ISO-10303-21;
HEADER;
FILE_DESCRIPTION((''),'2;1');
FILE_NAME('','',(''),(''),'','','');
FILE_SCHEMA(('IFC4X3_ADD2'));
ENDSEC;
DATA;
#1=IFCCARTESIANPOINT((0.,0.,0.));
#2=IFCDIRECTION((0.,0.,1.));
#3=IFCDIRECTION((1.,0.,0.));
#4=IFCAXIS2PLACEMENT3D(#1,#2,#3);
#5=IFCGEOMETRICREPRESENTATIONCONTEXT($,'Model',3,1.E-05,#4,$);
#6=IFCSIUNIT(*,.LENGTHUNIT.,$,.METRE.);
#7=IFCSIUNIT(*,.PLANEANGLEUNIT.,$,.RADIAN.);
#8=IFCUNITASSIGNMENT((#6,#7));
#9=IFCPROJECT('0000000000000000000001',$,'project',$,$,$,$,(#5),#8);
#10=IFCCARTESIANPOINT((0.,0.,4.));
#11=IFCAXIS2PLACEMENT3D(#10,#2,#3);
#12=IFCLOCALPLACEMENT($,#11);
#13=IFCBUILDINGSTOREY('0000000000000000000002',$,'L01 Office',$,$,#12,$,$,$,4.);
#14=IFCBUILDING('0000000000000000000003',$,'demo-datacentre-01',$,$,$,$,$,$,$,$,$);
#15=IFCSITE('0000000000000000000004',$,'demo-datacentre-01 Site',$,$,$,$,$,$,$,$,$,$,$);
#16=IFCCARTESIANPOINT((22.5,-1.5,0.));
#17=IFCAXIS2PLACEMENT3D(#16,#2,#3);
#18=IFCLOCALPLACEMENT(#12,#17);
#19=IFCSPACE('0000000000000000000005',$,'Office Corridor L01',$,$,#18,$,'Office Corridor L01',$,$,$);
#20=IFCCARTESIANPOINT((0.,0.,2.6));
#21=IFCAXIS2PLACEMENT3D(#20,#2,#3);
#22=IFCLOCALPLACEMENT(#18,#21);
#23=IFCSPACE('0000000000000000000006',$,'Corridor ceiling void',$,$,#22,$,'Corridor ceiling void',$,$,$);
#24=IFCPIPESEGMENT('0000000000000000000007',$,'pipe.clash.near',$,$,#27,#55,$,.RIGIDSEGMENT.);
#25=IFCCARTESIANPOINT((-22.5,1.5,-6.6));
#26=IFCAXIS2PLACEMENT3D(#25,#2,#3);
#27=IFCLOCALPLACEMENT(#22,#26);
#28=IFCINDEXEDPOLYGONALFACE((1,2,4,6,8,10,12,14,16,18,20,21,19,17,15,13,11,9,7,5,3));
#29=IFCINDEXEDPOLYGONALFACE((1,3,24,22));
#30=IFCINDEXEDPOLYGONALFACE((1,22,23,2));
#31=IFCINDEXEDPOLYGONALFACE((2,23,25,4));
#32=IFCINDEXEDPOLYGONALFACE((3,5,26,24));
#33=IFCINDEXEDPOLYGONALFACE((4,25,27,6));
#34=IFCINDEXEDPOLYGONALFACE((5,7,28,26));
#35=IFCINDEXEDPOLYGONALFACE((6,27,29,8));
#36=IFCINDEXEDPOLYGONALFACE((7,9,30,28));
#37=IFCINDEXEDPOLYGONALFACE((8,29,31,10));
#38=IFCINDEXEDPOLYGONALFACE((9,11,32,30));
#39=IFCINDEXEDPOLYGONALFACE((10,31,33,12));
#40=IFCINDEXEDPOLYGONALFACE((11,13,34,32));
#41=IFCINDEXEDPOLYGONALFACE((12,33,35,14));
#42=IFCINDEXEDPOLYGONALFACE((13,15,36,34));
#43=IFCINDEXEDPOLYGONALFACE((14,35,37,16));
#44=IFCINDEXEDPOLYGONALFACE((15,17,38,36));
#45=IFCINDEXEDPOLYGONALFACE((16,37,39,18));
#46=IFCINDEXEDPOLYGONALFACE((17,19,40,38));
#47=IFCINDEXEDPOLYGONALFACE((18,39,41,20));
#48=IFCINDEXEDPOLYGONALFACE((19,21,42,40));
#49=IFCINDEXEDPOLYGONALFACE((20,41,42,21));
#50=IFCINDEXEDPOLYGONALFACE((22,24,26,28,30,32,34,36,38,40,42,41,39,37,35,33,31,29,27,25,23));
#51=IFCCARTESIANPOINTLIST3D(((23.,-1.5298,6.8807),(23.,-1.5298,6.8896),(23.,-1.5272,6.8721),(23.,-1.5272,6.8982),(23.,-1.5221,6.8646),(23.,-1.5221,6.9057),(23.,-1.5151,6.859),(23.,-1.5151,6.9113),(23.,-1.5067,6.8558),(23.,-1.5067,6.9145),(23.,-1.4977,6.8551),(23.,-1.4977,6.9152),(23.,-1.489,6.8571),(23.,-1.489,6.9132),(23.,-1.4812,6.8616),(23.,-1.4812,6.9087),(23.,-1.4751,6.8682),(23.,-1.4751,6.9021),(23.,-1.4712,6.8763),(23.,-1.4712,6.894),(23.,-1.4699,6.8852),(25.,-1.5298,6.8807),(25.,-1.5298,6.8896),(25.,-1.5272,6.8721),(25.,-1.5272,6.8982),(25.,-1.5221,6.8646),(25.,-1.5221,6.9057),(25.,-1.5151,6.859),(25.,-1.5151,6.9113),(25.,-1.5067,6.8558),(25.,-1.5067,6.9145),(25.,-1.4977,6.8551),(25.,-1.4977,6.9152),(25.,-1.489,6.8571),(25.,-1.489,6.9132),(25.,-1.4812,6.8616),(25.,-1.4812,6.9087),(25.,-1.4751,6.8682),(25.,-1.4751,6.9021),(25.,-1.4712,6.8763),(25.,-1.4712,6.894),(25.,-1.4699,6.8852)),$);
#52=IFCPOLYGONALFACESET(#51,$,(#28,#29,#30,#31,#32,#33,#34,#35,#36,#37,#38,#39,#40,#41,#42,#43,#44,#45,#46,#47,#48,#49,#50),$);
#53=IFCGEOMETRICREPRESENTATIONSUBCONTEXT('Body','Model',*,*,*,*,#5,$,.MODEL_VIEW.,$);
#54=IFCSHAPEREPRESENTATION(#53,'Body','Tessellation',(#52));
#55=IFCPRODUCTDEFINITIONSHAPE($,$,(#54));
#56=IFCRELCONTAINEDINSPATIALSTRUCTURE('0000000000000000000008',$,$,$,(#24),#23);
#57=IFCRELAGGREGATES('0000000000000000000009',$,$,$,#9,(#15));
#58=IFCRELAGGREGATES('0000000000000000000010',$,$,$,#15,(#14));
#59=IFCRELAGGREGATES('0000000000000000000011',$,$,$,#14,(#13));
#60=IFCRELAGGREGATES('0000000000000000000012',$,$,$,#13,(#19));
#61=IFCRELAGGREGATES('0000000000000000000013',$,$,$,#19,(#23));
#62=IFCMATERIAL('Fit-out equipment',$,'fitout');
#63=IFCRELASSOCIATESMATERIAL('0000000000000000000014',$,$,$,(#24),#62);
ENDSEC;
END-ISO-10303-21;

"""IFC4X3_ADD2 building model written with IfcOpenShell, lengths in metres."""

from ifc_helpers import new_model, si_unit, frame, origin_with_axes, place, context, subcontext, project, spatial, circle, extrude, material, element, save


model = new_model("IFC4X3_ADD2")

# Units and contexts
model_context = context("Model", 3, precision=1e-05, world=origin_with_axes())
body_context = subcontext(model_context, "Body", "Model", "MODEL_VIEW")
ifc_project = project(units=[si_unit("LENGTHUNIT", "METRE"), si_unit("PLANEANGLEUNIT", "RADIAN")], contexts=[model_context])

# Site, building, storey, spaces
site = spatial("IfcSite", under=ifc_project, Name="demo-datacentre-01 Site")
building = spatial("IfcBuilding", under=site, Name="demo-datacentre-01")
storey_placement = place(None, frame((0.0, 0.0, 4.0), z_axis=(0.0, 0.0, 1.0), x_axis=(1.0, 0.0, 0.0)))
storey = spatial("IfcBuildingStorey", under=building, at=storey_placement, Name="L01 Office", Elevation=4.0)
space_1_placement = place(storey_placement, frame((22.5, -1.5, 0.0), z_axis=(0.0, 0.0, 1.0), x_axis=(1.0, 0.0, 0.0)))
space_1 = spatial("IfcSpace", under=storey, at=space_1_placement, Name="Office Corridor L01", LongName="Office Corridor L01")
space_2_placement = place(space_1_placement, frame((0.0, 0.0, 2.6), z_axis=(0.0, 0.0, 1.0), x_axis=(1.0, 0.0, 0.0)))
space_2 = spatial("IfcSpace", under=space_1, at=space_2_placement, Name="Corridor ceiling void", LongName="Corridor ceiling void")

# Pipe segment
ifc_material = material(Name="Fit-out equipment", Category="fitout")
pipe_segment_1_placement = place(space_2_placement, frame((-22.5, 1.5, -6.6), z_axis=(0.0, 0.0, 1.0), x_axis=(1.0, 0.0, 0.0)))
element("IfcPipeSegment", 1, at=pipe_segment_1_placement, inside=space_2, material=ifc_material, Name="pipe.clash.near", PredefinedType="RIGIDSEGMENT", context=body_context, shape_type="SweptSolid", body=[
    extrude(circle(Radius=0.0301), frame((23.0, -1.5, 6.8852), z_axis=(1.0, 0.0, 0.0), x_axis=(0.0, 1.0, 0.0)), (0.0, 0.0, 1.0), 2.0),
])

save(model, "model.ifc")
